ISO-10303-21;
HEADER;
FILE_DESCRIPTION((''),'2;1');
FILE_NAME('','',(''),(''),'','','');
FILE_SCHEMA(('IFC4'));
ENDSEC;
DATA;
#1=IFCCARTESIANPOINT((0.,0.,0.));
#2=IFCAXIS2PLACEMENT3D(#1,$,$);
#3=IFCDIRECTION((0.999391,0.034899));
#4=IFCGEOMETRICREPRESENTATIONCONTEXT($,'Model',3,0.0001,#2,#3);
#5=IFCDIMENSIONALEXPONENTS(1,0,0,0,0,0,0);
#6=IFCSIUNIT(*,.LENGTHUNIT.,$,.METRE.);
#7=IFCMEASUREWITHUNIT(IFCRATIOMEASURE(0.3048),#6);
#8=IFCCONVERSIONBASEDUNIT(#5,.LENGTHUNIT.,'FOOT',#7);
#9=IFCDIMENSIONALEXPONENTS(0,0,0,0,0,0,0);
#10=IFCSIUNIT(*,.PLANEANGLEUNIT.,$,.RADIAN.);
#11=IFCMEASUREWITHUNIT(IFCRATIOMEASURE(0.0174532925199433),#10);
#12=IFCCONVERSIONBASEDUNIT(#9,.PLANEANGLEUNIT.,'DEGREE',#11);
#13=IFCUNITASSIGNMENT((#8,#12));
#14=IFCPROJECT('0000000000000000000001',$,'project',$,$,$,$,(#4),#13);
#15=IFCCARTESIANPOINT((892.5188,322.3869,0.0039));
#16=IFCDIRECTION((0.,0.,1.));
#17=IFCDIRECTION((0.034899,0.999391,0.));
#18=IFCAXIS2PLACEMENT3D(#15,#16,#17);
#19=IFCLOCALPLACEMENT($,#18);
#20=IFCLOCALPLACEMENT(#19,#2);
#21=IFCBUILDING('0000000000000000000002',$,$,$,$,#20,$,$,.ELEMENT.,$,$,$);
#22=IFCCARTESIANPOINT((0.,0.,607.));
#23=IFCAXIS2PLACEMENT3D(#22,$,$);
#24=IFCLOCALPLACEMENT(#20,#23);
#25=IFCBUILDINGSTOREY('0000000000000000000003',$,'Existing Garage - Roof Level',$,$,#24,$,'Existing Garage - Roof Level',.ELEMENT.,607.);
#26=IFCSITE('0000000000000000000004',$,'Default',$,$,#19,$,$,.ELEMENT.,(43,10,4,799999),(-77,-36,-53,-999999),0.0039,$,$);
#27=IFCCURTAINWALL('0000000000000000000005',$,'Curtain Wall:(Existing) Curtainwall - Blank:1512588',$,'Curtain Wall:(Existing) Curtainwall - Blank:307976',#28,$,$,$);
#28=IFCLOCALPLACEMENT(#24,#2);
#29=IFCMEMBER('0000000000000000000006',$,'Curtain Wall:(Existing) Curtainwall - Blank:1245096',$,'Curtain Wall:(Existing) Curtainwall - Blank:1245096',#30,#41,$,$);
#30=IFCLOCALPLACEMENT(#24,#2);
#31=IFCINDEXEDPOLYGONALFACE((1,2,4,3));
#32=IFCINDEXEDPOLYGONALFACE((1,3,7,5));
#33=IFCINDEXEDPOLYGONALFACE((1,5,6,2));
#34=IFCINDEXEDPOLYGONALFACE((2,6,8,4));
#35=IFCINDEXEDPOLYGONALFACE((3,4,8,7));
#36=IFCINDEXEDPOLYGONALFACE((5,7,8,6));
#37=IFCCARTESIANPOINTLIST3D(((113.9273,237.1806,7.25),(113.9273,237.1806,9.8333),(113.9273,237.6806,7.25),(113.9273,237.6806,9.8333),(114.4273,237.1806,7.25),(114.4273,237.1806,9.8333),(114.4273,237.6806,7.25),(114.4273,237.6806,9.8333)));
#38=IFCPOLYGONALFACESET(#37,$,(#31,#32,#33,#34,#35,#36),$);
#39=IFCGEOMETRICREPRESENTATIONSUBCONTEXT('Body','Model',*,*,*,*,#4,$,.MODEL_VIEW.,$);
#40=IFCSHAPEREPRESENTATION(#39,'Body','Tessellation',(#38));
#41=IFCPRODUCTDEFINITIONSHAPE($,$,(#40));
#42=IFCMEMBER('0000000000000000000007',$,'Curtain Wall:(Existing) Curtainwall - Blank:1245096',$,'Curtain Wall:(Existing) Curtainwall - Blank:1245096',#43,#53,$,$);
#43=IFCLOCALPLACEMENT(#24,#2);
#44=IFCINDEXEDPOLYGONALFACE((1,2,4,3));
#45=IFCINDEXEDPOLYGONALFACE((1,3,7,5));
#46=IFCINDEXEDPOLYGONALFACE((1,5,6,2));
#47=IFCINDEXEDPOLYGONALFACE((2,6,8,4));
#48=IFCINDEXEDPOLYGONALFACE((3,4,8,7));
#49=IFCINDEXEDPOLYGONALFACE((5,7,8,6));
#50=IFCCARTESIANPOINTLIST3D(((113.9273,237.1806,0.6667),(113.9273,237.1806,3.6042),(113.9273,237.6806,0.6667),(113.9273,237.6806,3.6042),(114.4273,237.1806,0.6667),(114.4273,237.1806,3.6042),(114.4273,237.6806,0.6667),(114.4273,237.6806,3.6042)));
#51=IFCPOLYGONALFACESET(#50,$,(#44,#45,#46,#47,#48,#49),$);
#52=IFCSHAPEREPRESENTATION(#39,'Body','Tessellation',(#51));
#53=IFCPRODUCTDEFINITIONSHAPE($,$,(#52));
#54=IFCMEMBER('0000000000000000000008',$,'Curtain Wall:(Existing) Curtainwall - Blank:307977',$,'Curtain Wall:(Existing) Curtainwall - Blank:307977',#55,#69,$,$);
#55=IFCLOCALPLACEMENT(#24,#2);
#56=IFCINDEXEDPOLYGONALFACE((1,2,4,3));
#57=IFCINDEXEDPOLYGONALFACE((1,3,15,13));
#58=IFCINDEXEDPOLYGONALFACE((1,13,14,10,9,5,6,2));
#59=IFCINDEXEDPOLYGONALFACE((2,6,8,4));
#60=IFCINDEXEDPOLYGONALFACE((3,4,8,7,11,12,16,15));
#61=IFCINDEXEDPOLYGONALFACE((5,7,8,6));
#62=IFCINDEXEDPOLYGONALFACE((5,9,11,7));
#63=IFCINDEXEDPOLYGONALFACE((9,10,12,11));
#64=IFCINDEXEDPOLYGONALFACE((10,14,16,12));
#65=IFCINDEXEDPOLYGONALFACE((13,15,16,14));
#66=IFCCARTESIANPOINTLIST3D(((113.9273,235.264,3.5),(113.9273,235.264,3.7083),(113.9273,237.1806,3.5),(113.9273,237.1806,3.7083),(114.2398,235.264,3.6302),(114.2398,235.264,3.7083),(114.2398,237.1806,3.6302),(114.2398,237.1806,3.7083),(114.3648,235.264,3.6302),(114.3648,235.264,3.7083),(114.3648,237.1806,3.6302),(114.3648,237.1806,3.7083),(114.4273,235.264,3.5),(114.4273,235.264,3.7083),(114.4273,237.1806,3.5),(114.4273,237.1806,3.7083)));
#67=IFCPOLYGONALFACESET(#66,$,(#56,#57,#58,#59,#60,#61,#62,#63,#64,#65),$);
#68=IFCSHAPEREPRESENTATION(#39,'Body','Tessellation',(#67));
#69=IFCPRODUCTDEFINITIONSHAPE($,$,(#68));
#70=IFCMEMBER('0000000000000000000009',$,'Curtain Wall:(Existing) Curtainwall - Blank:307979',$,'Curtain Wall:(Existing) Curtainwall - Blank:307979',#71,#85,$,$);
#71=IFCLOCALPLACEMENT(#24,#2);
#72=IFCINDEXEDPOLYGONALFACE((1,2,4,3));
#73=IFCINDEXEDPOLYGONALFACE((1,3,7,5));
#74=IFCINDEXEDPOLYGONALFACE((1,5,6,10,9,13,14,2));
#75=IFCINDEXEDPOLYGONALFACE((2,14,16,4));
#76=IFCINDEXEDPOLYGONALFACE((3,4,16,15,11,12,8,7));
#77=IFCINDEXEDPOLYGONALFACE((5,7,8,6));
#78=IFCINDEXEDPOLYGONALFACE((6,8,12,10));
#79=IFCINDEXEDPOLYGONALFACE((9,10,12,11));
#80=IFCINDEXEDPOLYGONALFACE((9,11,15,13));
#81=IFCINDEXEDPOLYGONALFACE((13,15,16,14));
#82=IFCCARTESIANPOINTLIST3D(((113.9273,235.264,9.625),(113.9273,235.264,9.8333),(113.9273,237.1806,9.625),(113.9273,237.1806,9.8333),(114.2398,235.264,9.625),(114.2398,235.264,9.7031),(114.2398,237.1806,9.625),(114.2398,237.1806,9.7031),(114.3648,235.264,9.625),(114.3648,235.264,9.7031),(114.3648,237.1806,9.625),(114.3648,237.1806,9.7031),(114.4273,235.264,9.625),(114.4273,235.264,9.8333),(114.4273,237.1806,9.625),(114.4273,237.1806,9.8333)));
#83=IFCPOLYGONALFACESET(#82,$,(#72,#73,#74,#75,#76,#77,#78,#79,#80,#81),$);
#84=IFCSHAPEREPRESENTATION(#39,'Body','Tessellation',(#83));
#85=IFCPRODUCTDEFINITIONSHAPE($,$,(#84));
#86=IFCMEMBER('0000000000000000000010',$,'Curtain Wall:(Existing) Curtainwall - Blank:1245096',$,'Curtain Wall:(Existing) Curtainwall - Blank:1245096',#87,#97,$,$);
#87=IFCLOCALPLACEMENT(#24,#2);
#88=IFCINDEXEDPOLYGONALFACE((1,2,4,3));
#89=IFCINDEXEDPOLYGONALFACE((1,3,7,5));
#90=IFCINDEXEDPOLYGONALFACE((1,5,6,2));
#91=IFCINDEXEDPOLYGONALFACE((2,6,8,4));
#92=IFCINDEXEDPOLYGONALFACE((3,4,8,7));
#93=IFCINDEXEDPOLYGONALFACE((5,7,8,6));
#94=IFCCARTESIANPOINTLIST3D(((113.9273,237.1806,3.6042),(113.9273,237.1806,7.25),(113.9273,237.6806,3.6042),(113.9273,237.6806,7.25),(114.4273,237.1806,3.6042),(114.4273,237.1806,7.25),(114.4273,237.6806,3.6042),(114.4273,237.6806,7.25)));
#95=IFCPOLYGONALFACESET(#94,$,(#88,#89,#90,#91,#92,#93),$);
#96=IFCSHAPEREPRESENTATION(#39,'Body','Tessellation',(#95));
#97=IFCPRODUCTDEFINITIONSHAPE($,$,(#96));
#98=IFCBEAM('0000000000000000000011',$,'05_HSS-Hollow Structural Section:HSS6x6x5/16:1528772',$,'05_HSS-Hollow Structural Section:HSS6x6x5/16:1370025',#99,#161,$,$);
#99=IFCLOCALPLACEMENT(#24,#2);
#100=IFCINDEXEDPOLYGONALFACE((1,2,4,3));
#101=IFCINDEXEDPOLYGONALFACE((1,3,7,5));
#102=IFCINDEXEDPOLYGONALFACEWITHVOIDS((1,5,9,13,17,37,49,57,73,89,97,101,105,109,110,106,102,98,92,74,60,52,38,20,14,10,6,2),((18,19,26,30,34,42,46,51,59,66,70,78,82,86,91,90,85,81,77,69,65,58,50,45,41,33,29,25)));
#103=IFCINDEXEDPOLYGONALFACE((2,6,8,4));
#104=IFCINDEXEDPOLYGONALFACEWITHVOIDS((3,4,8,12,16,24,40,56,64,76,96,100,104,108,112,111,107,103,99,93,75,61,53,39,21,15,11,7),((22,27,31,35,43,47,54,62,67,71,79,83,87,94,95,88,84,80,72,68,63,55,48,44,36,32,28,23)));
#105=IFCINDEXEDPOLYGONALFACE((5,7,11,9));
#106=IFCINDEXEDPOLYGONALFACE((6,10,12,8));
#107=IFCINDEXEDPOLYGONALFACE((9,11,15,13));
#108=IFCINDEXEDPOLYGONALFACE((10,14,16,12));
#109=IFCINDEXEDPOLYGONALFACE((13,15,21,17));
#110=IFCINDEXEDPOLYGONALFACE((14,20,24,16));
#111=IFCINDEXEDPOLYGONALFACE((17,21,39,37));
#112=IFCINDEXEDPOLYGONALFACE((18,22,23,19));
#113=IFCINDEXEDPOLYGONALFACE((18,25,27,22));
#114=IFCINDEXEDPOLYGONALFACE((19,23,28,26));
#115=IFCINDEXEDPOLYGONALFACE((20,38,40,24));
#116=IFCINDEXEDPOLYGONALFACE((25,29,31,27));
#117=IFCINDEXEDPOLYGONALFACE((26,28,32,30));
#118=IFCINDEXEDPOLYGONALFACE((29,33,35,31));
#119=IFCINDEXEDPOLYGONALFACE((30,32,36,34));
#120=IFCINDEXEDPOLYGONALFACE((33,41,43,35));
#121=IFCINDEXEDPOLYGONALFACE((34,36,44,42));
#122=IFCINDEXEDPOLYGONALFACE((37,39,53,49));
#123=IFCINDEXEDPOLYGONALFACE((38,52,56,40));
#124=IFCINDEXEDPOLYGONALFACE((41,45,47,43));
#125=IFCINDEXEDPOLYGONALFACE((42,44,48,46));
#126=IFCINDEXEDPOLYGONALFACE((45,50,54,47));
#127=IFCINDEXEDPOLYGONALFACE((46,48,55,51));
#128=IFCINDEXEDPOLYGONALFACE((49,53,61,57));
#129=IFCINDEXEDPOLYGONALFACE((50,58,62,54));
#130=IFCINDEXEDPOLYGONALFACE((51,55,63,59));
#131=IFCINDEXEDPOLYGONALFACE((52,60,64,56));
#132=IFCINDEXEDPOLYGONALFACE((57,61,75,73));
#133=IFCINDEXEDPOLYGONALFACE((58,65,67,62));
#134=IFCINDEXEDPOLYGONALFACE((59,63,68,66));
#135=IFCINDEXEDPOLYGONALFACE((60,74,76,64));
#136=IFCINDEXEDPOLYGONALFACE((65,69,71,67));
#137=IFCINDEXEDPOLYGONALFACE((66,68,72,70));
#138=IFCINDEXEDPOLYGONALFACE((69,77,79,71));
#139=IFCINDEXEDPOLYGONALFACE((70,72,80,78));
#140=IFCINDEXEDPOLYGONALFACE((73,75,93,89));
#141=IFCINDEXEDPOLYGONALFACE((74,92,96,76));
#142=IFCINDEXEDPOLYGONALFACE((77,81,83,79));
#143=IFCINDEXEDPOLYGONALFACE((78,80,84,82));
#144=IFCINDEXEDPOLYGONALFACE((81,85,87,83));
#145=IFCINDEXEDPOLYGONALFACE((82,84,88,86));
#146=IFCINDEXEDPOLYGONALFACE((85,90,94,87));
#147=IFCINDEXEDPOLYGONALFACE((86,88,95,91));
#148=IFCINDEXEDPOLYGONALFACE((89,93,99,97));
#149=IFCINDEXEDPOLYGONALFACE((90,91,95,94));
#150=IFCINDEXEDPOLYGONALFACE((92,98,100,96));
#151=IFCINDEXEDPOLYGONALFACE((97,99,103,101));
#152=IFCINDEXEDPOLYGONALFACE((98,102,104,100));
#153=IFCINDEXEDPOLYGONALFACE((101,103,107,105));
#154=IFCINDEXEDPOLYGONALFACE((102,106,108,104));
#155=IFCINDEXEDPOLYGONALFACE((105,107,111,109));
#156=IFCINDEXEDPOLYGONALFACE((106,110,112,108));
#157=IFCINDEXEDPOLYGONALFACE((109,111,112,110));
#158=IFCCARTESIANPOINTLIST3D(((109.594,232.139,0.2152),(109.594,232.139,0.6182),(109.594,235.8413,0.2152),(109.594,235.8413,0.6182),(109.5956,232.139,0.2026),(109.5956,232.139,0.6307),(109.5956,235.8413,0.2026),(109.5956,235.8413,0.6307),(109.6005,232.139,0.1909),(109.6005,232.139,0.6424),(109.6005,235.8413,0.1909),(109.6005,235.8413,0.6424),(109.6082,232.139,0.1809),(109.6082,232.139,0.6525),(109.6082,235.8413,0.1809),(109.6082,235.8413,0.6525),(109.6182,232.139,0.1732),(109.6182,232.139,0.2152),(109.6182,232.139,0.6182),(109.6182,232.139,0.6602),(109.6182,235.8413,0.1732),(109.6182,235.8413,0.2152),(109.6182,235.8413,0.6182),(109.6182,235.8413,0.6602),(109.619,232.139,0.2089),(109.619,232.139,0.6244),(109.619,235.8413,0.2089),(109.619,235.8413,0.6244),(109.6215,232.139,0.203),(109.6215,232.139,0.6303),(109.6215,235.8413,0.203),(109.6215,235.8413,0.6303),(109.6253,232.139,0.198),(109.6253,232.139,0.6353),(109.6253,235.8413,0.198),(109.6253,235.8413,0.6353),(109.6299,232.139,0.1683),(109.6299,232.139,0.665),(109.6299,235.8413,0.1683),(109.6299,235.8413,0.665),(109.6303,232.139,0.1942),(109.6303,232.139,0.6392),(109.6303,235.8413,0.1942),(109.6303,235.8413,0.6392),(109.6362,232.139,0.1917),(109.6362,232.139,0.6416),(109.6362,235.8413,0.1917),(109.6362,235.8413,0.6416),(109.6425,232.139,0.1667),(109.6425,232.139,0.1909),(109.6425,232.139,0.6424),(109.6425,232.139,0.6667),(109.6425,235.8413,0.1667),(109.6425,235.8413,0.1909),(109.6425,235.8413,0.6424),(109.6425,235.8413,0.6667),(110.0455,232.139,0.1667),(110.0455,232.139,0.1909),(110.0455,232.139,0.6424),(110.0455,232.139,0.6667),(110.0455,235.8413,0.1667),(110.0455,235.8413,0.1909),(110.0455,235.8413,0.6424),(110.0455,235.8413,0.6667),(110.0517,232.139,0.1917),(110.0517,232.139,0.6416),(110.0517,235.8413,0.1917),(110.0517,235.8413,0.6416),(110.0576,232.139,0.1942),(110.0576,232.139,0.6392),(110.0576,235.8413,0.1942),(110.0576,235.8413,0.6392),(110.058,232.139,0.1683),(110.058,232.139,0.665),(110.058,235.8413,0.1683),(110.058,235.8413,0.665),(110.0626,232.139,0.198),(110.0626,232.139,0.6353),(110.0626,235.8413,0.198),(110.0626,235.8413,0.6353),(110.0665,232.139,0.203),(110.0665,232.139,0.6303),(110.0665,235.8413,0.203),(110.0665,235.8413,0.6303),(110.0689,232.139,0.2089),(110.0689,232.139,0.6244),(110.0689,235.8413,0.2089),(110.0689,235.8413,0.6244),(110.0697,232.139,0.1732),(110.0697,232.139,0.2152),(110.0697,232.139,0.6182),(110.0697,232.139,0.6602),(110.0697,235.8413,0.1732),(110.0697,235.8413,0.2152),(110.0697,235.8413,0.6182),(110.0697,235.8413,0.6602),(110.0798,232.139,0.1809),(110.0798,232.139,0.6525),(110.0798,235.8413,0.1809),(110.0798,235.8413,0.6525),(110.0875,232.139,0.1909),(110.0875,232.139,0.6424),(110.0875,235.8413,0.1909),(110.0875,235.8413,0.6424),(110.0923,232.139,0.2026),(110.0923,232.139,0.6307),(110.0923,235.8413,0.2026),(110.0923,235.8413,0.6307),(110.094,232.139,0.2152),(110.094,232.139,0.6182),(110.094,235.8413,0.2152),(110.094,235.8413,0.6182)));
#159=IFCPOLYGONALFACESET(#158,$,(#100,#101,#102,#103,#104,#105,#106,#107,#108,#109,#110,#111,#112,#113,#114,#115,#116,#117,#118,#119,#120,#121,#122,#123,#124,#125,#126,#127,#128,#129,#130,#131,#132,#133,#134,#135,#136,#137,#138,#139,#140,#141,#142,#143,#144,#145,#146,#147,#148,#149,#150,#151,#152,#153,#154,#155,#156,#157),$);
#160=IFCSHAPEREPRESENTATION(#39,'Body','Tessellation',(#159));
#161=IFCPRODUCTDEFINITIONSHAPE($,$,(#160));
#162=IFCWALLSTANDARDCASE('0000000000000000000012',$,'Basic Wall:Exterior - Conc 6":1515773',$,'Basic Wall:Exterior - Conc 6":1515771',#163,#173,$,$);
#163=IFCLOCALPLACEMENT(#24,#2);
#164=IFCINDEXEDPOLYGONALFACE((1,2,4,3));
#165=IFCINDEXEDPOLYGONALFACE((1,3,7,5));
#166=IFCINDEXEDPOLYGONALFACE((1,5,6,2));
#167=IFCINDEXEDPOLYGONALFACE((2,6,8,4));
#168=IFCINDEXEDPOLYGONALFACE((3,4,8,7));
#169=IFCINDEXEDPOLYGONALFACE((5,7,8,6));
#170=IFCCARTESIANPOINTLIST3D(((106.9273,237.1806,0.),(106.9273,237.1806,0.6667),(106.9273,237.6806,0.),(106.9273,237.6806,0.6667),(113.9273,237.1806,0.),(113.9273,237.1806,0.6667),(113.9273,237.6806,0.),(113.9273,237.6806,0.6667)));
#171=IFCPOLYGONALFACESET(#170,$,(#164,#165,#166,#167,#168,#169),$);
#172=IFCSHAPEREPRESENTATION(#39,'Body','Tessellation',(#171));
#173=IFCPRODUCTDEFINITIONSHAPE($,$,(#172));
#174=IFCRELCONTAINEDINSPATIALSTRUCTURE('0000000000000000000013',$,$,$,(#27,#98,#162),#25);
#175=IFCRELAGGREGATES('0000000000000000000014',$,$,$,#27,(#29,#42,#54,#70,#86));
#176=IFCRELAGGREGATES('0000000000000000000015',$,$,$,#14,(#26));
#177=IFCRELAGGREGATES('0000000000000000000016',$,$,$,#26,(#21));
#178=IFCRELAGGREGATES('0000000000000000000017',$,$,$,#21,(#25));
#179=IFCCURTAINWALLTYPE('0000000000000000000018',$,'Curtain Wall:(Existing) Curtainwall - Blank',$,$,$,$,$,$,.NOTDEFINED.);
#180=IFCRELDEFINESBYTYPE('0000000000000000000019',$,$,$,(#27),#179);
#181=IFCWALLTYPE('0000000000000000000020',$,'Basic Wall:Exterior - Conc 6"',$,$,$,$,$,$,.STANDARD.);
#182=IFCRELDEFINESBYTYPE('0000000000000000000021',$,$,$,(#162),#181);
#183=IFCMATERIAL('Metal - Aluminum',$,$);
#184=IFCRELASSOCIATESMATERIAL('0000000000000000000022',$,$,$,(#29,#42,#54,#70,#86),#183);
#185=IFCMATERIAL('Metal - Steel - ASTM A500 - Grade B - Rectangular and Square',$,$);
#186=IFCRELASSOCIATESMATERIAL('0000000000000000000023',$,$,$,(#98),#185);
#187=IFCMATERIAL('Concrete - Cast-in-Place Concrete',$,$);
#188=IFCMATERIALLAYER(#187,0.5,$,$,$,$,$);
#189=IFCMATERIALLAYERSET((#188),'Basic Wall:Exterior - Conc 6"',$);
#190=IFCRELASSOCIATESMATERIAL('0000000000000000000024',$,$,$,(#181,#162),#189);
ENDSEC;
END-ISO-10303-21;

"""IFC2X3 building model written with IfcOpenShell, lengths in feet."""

from ifc_helpers import new_model, entity, si_unit, converted_unit, direction, frame, frame_2d, origin, origin_2d_with_axis, place, context, subcontext, project, spatial, polyline, circle_curve, parameter, trimmed, segment, composite_curve, rectangle, outline, extrude, material, layer, layer_set, layer_usage, type_object, element, aggregate, save


model = new_model("IFC2X3")

# Units and contexts
model_context = context("Model", 3, precision=0.0001, world=origin(), true_north=direction((0.999391, 0.034899)))
body_context = subcontext(model_context, "Body", "Model", "MODEL_VIEW")
ifc_project = project(units=[converted_unit("LENGTHUNIT", "FOOT", entity("IfcRatioMeasure", 0.3048), si_unit("LENGTHUNIT", "METRE"), dimensions=[1, 0, 0, 0, 0, 0, 0]), converted_unit("PLANEANGLEUNIT", "DEGREE", entity("IfcRatioMeasure", 0.0174532925199433), si_unit("PLANEANGLEUNIT", "RADIAN"), dimensions=[0, 0, 0, 0, 0, 0, 0])], contexts=[model_context])

# Site, building, storey
site_placement = place(None, frame((892.5188, 322.3869, 0.0039), z_axis=(0.0, 0.0, 1.0), x_axis=(0.034899, 0.999391, 0.0)))
site = spatial("IfcSite", under=ifc_project, at=site_placement, Name="Default", CompositionType="ELEMENT", RefLatitude=(43, 10, 4, 799999), RefLongitude=(-77, -36, -53, -999999), RefElevation=0.0039)
building_placement = place(site_placement, origin())
building = spatial("IfcBuilding", under=site, at=building_placement, CompositionType="ELEMENT")
storey_placement = place(building_placement, frame((0.0, 0.0, 607.0)))
storey = spatial("IfcBuildingStorey", under=building, at=storey_placement, Name="Existing Garage - Roof Level", LongName="Existing Garage - Roof Level", CompositionType="ELEMENT", Elevation=607.0)

# Shared definitions
ifc_material_1 = material(Name="Metal - Steel - ASTM A500 - Grade B - Rectangular and Square")
ifc_material_2 = material(Name="Concrete - Cast-in-Place Concrete")

# Curtain wall, members
curtain_wall_type = type_object("IfcCurtainWallType", Name="Curtain Wall:(Existing) Curtainwall - Blank", PredefinedType="NOTDEFINED")
ifc_material_3 = material(Name="Metal - Aluminum")
curtain_wall_1_placement = place(storey_placement, frame((0.0, 0.0, -607.0)))
curtain_wall_1 = element("IfcCurtainWall", 1, at=curtain_wall_1_placement, inside=storey, type_object=curtain_wall_type, Name="Curtain Wall:(Existing) Curtainwall - Blank:1512588", ObjectType="Curtain Wall:(Existing) Curtainwall - Blank:307976")
member_1_placement = place(curtain_wall_1_placement, frame((0.0, 0.0, 607.0)))
member_1 = element("IfcMember", 2, at=member_1_placement, material=ifc_material_3, Name="Curtain Wall:(Existing) Curtainwall - Blank:1245096", ObjectType="Curtain Wall:(Existing) Curtainwall - Blank:1245096", context=body_context, shape_type="SweptSolid", body=[
    extrude(rectangle(XDim=0.5, YDim=0.5, at=origin_2d_with_axis()), frame((114.1773, 237.4306, 9.8333), z_axis=(0.0, 0.0, -1.0), x_axis=(-1.0, 0.0, 0.0)), (0.0, 0.0, 1.0), 2.5833),
])
member_2_placement = place(curtain_wall_1_placement, frame((0.0, 0.0, 607.0)))
member_2 = element("IfcMember", 3, at=member_2_placement, material=ifc_material_3, Name="Curtain Wall:(Existing) Curtainwall - Blank:1245096", ObjectType="Curtain Wall:(Existing) Curtainwall - Blank:1245096", context=body_context, shape_type="SweptSolid", body=[
    extrude(rectangle(XDim=0.5, YDim=0.5, at=origin_2d_with_axis()), frame((114.1773, 237.4306, 3.6042), z_axis=(0.0, 0.0, -1.0), x_axis=(-1.0, 0.0, 0.0)), (0.0, 0.0, 1.0), 2.9375),
])
member_3_placement = place(curtain_wall_1_placement, frame((0.0, 0.0, 607.0)))
member_3 = element("IfcMember", 4, at=member_3_placement, material=ifc_material_3, Name="Curtain Wall:(Existing) Curtainwall - Blank:307977", ObjectType="Curtain Wall:(Existing) Curtainwall - Blank:307977", context=body_context, shape_type="SweptSolid", body=[
    extrude(outline(polyline([(-0.0716, -0.1875), (0.1367, -0.1875), (0.1367, 0.3125), (-0.0716, 0.3125), (-0.0716, 0.0), (0.0065, 0.0), (0.0065, -0.125), (-0.0716, -0.125), (-0.0716, -0.1875)])), frame((114.2398, 235.264, 3.6367), z_axis=(0.0, 1.0, 0.0), x_axis=(0.0, 0.0, -1.0)), (0.0, 0.0, 1.0), 1.9167),
])
member_4_placement = place(curtain_wall_1_placement, frame((0.0, 0.0, 607.0)))
member_4 = element("IfcMember", 5, at=member_4_placement, material=ifc_material_3, Name="Curtain Wall:(Existing) Curtainwall - Blank:307979", ObjectType="Curtain Wall:(Existing) Curtainwall - Blank:307979", context=body_context, shape_type="SweptSolid", body=[
    extrude(outline(polyline([(-0.1367, -0.1875), (0.0716, -0.1875), (0.0716, -0.125), (-0.0065, -0.125), (-0.0065, 0.0), (0.0716, 0.0), (0.0716, 0.3125), (-0.1367, 0.3125), (-0.1367, -0.1875)])), frame((114.2398, 235.264, 9.6966), z_axis=(0.0, 1.0, 0.0), x_axis=(0.0, 0.0, -1.0)), (0.0, 0.0, 1.0), 1.9167),
])
member_5_placement = place(curtain_wall_1_placement, frame((0.0, 0.0, 607.0)))
member_5 = element("IfcMember", 6, at=member_5_placement, material=ifc_material_3, Name="Curtain Wall:(Existing) Curtainwall - Blank:1245096", ObjectType="Curtain Wall:(Existing) Curtainwall - Blank:1245096", context=body_context, shape_type="SweptSolid", body=[
    extrude(rectangle(XDim=0.5, YDim=0.5, at=origin_2d_with_axis()), frame((114.1773, 237.4306, 7.25), z_axis=(0.0, 0.0, -1.0), x_axis=(-1.0, 0.0, 0.0)), (0.0, 0.0, 1.0), 3.6458),
])
aggregate(curtain_wall_1, [member_1, member_2, member_3, member_4, member_5])

# Beam
beam_1_placement = place(storey_placement, frame((109.844, 231.8473, 0.6667), z_axis=(0.0, 0.0, 1.0), x_axis=(0.0, 1.0, 0.0)))
element("IfcBeam", 7, at=beam_1_placement, inside=storey, material=ifc_material_1, Name="05_HSS-Hollow Structural Section:HSS6x6x5/16:1528772", ObjectType="05_HSS-Hollow Structural Section:HSS6x6x5/16:1370025", context=body_context, shape_type="SweptSolid", body=[
    extrude(outline(composite_curve([segment(trimmed(circle_curve(frame_2d((-0.2015, -0.2015), x_axis=(1.0, 0.0)), 0.0485), [parameter(180.0)], [parameter(270.0)], True, "PARAMETER"), True, "CONTINUOUS"), segment(polyline([(-0.2015, -0.25), (0.2015, -0.25)]), True, "CONTINUOUS"), segment(trimmed(circle_curve(frame_2d((0.2015, -0.2015), x_axis=(1.0, 0.0)), 0.0485), [parameter(270.0)], [parameter(0.0)], True, "PARAMETER"), True, "CONTINUOUS"), segment(polyline([(0.25, -0.2015), (0.25, 0.2015)]), True, "CONTINUOUS"), segment(trimmed(circle_curve(frame_2d((0.2015, 0.2015), x_axis=(1.0, 0.0)), 0.0485), [parameter(360.0)], [parameter(90.0)], True, "PARAMETER"), True, "CONTINUOUS"), segment(polyline([(0.2015, 0.25), (-0.2015, 0.25)]), True, "CONTINUOUS"), segment(trimmed(circle_curve(frame_2d((-0.2015, 0.2015), x_axis=(1.0, 0.0)), 0.0485), [parameter(90.0)], [parameter(180.0)], True, "PARAMETER"), True, "CONTINUOUS"), segment(polyline([(-0.25, 0.2015), (-0.25, -0.2015)]), True, "CONTINUOUS")], self_intersect=False), holes=[composite_curve([segment(polyline([(0.2015, -0.2257), (-0.2015, -0.2257)]), True, "CONTINUOUS"), segment(trimmed(circle_curve(frame_2d((-0.2015, -0.2015), x_axis=(1.0, 0.0)), 0.0243), [parameter(180.0)], [parameter(270.0)], True, "PARAMETER"), False, "CONTINUOUS"), segment(polyline([(-0.2257, -0.2015), (-0.2257, 0.2015)]), True, "CONTINUOUS"), segment(trimmed(circle_curve(frame_2d((-0.2015, 0.2015), x_axis=(1.0, 0.0)), 0.0243), [parameter(90.0)], [parameter(180.0)], True, "PARAMETER"), False, "CONTINUOUS"), segment(polyline([(-0.2015, 0.2258), (0.2015, 0.2258)]), True, "CONTINUOUS"), segment(trimmed(circle_curve(frame_2d((0.2015, 0.2015), x_axis=(1.0, 0.0)), 0.0243), [parameter(0.0)], [parameter(90.0)], True, "PARAMETER"), False, "CONTINUOUS"), segment(polyline([(0.2258, 0.2015), (0.2258, -0.2015)]), True, "CONTINUOUS"), segment(trimmed(circle_curve(frame_2d((0.2015, -0.2015), x_axis=(1.0, 0.0)), 0.0243), [parameter(270.0)], [parameter(0.0)], True, "PARAMETER"), False, "CONTINUOUS")], self_intersect=False)]), frame((0.2917, 0.0, -0.25), z_axis=(1.0, 0.0, 0.0), x_axis=(0.0, -1.0, 0.0)), (0.0, 0.0, 1.0), 3.7023),
])

# Wall
ifc_layer = layer(ifc_material_2, 0.5)
ifc_layer_set = layer_set([ifc_layer], Name="Basic Wall:Exterior - Conc 6\"")
ifc_layer_usage_1 = layer_usage(ifc_layer_set, "AXIS2", "NEGATIVE", 0.25)
wall_type = type_object("IfcWallType", Name="Basic Wall:Exterior - Conc 6\"", PredefinedType="STANDARD", material=ifc_layer_set)
wall_1_placement = place(storey_placement, frame((106.9273, 237.4306, 0.0)))
element("IfcWallStandardCase", 8, at=wall_1_placement, inside=storey, type_object=wall_type, material=ifc_layer_usage_1, Name="Basic Wall:Exterior - Conc 6\":1515773", ObjectType="Basic Wall:Exterior - Conc 6\":1515771", context=body_context, shape_type="SweptSolid", body=[
    extrude(rectangle(XDim=7.0, YDim=0.5, at=frame_2d((3.5, 0.0), x_axis=(-1.0, 0.0))), origin(), (0.0, 0.0, 1.0), 0.6667),
])

save(model, "model.ifc")
